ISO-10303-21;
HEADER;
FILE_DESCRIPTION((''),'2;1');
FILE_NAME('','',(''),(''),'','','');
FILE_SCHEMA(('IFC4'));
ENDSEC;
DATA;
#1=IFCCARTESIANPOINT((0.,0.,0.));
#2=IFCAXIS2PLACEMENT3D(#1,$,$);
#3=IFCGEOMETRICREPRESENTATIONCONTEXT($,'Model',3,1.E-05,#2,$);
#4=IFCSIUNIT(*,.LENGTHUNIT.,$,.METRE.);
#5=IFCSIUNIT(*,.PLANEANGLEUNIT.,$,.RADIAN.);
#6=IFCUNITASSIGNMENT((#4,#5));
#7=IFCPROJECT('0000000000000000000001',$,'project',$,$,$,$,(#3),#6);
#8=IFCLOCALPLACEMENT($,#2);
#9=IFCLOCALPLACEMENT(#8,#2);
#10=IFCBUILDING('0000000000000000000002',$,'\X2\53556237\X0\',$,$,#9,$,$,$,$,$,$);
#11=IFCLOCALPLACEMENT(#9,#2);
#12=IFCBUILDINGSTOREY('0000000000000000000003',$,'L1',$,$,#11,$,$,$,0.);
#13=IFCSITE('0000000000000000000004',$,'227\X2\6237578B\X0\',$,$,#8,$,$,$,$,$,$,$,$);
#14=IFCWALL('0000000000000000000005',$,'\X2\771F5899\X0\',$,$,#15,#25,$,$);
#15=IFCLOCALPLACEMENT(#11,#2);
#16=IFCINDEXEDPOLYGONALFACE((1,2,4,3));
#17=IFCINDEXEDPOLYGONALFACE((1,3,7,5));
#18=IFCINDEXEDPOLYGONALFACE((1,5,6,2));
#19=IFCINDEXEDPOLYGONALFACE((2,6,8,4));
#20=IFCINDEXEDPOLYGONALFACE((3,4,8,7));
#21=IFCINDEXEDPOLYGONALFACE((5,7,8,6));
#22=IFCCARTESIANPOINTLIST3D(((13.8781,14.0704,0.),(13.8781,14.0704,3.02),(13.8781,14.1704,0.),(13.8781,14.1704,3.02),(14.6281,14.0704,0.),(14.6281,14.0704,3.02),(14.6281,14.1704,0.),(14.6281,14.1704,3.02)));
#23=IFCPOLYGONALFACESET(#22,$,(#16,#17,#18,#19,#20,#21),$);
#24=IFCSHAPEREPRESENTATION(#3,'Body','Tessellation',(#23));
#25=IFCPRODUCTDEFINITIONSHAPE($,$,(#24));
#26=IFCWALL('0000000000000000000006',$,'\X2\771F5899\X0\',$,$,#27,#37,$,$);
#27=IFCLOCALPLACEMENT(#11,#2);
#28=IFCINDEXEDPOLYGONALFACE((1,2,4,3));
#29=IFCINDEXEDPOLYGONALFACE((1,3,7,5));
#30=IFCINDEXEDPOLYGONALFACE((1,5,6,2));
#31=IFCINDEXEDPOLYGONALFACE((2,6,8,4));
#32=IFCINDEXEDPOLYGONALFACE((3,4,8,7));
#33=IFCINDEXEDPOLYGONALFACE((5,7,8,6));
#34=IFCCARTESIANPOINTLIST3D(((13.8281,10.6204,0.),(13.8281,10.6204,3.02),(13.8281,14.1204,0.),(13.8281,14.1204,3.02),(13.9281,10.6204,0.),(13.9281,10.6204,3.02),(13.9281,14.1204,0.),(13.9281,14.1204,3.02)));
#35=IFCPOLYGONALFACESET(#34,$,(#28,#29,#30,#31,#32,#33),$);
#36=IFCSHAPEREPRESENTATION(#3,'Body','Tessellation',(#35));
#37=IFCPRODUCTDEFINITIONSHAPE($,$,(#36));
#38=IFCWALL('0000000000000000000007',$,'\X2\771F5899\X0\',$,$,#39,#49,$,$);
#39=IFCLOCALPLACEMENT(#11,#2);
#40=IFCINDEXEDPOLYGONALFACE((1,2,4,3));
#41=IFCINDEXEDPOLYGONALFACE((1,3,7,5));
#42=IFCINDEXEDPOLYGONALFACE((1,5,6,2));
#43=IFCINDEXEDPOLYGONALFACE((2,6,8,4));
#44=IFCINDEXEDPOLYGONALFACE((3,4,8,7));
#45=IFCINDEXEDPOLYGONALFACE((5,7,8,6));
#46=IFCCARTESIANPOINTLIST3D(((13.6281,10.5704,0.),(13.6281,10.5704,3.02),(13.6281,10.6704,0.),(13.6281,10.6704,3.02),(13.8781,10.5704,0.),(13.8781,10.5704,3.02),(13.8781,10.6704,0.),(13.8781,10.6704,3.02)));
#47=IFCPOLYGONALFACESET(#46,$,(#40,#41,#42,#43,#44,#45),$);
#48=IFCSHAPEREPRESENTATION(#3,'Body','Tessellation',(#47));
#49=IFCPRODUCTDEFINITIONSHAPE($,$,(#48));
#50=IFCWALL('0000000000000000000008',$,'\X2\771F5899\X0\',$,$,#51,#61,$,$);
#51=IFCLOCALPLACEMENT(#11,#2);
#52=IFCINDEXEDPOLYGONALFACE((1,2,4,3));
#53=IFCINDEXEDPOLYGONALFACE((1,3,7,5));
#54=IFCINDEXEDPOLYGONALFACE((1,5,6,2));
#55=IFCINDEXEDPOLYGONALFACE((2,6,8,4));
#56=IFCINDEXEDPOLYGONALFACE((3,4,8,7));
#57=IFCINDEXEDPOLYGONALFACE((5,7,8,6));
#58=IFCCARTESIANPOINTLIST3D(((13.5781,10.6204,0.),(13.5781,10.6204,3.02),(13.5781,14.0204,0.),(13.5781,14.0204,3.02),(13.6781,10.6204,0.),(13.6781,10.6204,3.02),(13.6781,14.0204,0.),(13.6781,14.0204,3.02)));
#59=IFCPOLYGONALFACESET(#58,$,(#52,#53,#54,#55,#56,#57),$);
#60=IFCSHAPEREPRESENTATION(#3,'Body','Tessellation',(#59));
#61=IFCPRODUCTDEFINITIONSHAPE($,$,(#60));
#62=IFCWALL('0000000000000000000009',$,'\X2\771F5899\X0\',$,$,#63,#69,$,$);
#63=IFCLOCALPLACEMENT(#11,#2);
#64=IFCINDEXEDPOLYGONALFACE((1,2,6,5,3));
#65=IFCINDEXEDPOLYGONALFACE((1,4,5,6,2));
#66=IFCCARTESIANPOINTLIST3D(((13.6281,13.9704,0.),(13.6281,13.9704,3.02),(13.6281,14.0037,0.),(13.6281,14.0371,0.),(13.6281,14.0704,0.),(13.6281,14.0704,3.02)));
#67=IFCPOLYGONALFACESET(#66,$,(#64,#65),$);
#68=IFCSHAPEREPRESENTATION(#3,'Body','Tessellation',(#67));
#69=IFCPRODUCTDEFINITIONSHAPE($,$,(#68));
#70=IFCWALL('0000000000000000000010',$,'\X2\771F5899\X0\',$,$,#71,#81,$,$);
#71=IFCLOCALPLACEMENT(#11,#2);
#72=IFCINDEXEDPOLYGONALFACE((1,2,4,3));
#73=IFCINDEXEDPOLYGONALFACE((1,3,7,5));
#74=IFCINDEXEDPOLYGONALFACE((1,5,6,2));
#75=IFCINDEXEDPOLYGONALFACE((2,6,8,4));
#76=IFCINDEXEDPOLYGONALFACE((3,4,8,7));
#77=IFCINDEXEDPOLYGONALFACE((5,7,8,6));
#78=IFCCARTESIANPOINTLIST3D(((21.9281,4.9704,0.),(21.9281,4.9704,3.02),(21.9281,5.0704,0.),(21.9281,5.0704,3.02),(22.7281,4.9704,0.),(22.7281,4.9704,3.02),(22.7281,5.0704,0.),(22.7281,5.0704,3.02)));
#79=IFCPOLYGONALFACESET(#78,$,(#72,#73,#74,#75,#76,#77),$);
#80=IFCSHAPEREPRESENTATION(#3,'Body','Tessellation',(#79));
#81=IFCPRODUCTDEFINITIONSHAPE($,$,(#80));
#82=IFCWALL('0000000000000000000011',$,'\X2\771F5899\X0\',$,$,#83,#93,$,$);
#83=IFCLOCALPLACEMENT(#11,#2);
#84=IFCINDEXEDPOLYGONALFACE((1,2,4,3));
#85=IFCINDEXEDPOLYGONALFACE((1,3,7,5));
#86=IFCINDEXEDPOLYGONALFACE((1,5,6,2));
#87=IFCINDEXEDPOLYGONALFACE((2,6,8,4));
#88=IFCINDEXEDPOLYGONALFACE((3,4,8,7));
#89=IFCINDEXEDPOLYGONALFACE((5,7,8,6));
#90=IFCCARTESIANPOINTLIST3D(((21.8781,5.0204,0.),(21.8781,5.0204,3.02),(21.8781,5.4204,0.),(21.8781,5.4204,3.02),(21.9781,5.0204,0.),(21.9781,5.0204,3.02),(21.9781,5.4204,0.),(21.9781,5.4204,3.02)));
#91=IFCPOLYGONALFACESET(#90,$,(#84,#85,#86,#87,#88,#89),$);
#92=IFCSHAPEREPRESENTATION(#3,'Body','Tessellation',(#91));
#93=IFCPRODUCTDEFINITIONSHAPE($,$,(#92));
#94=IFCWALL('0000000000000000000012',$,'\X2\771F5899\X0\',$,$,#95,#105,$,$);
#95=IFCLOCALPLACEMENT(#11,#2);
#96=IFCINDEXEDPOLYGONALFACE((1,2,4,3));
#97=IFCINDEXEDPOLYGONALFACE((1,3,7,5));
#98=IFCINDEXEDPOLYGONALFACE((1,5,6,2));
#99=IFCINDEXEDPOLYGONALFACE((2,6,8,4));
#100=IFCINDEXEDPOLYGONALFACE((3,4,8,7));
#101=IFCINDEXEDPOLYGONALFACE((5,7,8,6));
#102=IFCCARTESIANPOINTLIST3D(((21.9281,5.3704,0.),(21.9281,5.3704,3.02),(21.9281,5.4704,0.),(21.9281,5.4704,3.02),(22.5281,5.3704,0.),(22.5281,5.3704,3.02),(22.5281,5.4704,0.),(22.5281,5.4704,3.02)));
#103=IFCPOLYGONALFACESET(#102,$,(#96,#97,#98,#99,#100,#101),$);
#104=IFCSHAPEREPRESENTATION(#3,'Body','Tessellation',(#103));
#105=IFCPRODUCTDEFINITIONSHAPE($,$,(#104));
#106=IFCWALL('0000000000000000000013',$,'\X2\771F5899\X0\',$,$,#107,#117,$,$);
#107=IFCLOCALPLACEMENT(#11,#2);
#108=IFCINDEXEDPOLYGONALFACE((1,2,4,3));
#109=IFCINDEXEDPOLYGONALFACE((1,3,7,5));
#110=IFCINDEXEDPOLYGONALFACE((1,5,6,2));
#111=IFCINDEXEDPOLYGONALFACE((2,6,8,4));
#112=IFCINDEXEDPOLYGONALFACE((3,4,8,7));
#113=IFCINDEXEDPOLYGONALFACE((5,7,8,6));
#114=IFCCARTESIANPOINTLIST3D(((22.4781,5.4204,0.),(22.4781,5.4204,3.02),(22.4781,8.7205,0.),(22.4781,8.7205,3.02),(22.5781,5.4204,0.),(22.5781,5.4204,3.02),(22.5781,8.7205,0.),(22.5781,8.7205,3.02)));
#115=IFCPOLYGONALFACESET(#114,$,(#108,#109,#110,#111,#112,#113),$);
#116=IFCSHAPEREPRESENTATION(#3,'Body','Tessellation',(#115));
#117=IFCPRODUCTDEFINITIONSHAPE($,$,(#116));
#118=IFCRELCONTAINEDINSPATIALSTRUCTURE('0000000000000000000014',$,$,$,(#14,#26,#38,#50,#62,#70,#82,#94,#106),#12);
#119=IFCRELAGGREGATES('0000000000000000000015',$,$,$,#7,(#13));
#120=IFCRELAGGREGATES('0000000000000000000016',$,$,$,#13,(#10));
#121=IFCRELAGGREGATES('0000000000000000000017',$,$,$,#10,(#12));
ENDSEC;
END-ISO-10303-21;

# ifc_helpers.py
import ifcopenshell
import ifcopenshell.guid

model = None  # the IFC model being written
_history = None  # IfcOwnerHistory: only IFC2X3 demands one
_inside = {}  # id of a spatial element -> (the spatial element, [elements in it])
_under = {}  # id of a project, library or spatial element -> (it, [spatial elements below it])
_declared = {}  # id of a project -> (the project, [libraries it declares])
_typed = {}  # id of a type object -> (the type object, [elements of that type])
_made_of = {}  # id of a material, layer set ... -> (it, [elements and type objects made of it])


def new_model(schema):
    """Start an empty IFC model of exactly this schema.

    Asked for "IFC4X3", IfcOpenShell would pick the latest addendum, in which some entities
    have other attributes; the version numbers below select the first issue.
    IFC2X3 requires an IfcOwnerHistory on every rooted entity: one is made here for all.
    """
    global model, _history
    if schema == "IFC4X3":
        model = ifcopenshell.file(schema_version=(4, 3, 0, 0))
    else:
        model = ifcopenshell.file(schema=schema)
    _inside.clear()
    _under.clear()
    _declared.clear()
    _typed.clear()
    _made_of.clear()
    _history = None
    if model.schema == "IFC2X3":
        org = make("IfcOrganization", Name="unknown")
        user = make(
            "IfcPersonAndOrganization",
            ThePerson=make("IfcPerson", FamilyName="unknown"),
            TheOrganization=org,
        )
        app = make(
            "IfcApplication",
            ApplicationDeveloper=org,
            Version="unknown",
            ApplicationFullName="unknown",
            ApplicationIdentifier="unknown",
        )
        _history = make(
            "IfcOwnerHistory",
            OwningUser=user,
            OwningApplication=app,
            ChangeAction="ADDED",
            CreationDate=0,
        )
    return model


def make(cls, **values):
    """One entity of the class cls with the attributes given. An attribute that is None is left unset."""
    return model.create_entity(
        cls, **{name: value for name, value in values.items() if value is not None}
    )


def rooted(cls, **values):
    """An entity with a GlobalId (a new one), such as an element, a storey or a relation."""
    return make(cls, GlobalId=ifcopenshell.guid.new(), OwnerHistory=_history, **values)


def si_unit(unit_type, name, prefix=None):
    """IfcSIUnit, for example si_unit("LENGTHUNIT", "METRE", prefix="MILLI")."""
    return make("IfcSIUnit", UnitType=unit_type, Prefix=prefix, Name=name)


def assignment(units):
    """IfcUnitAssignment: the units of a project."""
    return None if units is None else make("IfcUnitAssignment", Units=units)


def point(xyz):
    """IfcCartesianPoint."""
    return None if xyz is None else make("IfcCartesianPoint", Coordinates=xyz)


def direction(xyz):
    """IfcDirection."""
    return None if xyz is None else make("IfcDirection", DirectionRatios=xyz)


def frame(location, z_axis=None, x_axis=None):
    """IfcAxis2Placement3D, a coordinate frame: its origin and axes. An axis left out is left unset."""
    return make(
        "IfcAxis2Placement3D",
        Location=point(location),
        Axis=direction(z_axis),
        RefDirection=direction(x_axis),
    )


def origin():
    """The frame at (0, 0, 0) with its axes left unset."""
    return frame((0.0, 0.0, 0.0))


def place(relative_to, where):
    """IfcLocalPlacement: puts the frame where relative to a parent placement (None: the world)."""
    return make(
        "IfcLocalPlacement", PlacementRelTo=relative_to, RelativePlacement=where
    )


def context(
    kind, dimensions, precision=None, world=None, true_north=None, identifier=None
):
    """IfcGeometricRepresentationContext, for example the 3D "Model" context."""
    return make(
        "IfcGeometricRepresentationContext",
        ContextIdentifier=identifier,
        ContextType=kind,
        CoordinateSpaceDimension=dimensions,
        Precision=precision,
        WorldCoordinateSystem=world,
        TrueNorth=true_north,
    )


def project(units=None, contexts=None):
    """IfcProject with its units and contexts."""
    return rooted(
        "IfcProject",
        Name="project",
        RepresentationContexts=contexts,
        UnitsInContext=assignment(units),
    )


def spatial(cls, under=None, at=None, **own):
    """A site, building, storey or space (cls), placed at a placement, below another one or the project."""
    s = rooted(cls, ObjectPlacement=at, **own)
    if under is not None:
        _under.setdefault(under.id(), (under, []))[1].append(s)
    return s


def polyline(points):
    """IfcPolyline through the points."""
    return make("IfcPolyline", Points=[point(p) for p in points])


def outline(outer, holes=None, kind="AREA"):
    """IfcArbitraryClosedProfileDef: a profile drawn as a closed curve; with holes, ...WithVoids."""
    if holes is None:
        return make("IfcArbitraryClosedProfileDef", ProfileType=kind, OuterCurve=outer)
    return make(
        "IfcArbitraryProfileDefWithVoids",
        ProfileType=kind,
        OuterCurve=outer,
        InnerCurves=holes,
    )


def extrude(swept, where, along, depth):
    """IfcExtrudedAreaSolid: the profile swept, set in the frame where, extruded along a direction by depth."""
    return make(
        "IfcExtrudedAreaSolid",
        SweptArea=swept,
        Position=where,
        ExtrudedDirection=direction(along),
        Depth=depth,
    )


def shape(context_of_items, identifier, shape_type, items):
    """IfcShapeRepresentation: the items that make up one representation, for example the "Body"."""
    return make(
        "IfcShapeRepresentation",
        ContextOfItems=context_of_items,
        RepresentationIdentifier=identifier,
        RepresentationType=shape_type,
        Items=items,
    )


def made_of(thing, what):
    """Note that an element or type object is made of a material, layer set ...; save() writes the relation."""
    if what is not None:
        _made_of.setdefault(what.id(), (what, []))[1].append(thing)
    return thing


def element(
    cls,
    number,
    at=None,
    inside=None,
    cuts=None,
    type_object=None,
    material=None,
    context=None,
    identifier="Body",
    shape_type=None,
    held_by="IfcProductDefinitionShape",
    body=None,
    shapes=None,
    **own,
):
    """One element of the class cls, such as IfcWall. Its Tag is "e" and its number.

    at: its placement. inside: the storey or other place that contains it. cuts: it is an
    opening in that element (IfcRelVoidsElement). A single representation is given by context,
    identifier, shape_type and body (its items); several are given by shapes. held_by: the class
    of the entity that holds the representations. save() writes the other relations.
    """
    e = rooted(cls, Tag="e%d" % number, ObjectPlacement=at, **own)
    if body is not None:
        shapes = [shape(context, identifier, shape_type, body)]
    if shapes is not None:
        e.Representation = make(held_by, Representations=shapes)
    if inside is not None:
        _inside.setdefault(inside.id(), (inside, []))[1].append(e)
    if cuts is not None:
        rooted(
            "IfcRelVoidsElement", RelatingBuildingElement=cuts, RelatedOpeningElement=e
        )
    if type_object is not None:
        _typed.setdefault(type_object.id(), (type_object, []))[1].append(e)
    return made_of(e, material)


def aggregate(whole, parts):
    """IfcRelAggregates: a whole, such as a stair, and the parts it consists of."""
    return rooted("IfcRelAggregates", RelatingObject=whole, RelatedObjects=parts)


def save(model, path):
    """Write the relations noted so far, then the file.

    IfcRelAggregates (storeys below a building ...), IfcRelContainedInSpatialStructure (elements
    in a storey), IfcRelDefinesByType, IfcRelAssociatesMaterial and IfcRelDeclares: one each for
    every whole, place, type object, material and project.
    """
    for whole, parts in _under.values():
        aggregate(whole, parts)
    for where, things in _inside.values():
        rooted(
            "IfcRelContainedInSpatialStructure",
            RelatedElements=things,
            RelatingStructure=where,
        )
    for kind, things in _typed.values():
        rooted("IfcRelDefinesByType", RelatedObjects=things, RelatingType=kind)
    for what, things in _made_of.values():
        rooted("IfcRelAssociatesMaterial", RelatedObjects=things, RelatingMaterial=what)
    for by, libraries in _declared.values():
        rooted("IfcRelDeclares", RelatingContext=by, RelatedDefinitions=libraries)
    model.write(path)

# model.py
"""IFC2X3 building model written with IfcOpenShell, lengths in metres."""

from ifc_helpers import new_model, si_unit, origin, place, context, project, spatial, polyline, outline, extrude, element, save


model = new_model("IFC2X3")

# Units and contexts
model_context = context("Model", 3, precision=1e-05, world=origin())
ifc_project = project(units=[si_unit("LENGTHUNIT", "METRE"), si_unit("PLANEANGLEUNIT", "RADIAN")], contexts=[model_context])

# Site, building, storey
site_placement = place(None, origin())
site = spatial("IfcSite", under=ifc_project, at=site_placement, Name="227户型")
building_placement = place(site_placement, origin())
building = spatial("IfcBuilding", under=site, at=building_placement, Name="单户")
storey_placement = place(building_placement, origin())
storey = spatial("IfcBuildingStorey", under=building, at=storey_placement, Name="L1", Elevation=0.0)

# Walls
wall_1_placement = place(storey_placement, origin())
element("IfcWall", 1, at=wall_1_placement, inside=storey, Name="真墙", context=model_context, shape_type="SweptSolid", body=[
    extrude(outline(polyline([(14.6281, 14.0704), (13.8781, 14.0704), (13.8781, 14.1704), (14.6281, 14.1704), (14.6281, 14.0704)])), origin(), (0.0, 0.0, 1.0), 3.02),
])
wall_2_placement = place(storey_placement, origin())
element("IfcWall", 2, at=wall_2_placement, inside=storey, Name="真墙", context=model_context, shape_type="SweptSolid", body=[
    extrude(outline(polyline([(13.9281, 14.1204), (13.9281, 10.6204), (13.8281, 10.6204), (13.8281, 14.1204), (13.9281, 14.1204)])), origin(), (0.0, 0.0, 1.0), 3.02),
])
wall_3_placement = place(storey_placement, origin())
element("IfcWall", 3, at=wall_3_placement, inside=storey, Name="真墙", context=model_context, shape_type="SweptSolid", body=[
    extrude(outline(polyline([(13.8781, 10.5704), (13.6281, 10.5704), (13.6281, 10.6704), (13.8781, 10.6704), (13.8781, 10.5704)])), origin(), (0.0, 0.0, 1.0), 3.02),
])
wall_4_placement = place(storey_placement, origin())
element("IfcWall", 4, at=wall_4_placement, inside=storey, Name="真墙", context=model_context, shape_type="SweptSolid", body=[
    extrude(outline(polyline([(13.5781, 10.6204), (13.5781, 14.0204), (13.6781, 14.0204), (13.6781, 10.6204), (13.5781, 10.6204)])), origin(), (0.0, 0.0, 1.0), 3.02),
])
wall_5_placement = place(storey_placement, origin())
element("IfcWall", 5, at=wall_5_placement, inside=storey, Name="真墙", context=model_context, shape_type="SweptSolid", body=[
    extrude(outline(polyline([(13.6281, 13.9704), (13.6281, 13.9704), (13.6281, 14.0704), (13.6281, 14.0704), (13.6281, 13.9704)])), origin(), (0.0, 0.0, 1.0), 3.02),
])
wall_6_placement = place(storey_placement, origin())
element("IfcWall", 6, at=wall_6_placement, inside=storey, Name="真墙", context=model_context, shape_type="SweptSolid", body=[
    extrude(outline(polyline([(22.7281, 4.9704), (21.9281, 4.9704), (21.9281, 5.0704), (22.7281, 5.0704), (22.7281, 4.9704)])), origin(), (0.0, 0.0, 1.0), 3.02),
])
wall_7_placement = place(storey_placement, origin())
element("IfcWall", 7, at=wall_7_placement, inside=storey, Name="真墙", context=model_context, shape_type="SweptSolid", body=[
    extrude(outline(polyline([(21.8781, 5.0204), (21.8781, 5.4204), (21.9781, 5.4204), (21.9781, 5.0204), (21.8781, 5.0204)])), origin(), (0.0, 0.0, 1.0), 3.02),
])
wall_8_placement = place(storey_placement, origin())
element("IfcWall", 8, at=wall_8_placement, inside=storey, Name="真墙", context=model_context, shape_type="SweptSolid", body=[
    extrude(outline(polyline([(21.9281, 5.4704), (22.5281, 5.4704), (22.5281, 5.3704), (21.9281, 5.3704), (21.9281, 5.4704)])), origin(), (0.0, 0.0, 1.0), 3.02),
])
wall_9_placement = place(storey_placement, origin())
element("IfcWall", 9, at=wall_9_placement, inside=storey, Name="真墙", context=model_context, shape_type="SweptSolid", body=[
    extrude(outline(polyline([(22.4781, 5.4204), (22.4781, 8.7205), (22.5781, 8.7205), (22.5781, 5.4204), (22.4781, 5.4204)])), origin(), (0.0, 0.0, 1.0), 3.02),
])

save(model, "model.ifc")
